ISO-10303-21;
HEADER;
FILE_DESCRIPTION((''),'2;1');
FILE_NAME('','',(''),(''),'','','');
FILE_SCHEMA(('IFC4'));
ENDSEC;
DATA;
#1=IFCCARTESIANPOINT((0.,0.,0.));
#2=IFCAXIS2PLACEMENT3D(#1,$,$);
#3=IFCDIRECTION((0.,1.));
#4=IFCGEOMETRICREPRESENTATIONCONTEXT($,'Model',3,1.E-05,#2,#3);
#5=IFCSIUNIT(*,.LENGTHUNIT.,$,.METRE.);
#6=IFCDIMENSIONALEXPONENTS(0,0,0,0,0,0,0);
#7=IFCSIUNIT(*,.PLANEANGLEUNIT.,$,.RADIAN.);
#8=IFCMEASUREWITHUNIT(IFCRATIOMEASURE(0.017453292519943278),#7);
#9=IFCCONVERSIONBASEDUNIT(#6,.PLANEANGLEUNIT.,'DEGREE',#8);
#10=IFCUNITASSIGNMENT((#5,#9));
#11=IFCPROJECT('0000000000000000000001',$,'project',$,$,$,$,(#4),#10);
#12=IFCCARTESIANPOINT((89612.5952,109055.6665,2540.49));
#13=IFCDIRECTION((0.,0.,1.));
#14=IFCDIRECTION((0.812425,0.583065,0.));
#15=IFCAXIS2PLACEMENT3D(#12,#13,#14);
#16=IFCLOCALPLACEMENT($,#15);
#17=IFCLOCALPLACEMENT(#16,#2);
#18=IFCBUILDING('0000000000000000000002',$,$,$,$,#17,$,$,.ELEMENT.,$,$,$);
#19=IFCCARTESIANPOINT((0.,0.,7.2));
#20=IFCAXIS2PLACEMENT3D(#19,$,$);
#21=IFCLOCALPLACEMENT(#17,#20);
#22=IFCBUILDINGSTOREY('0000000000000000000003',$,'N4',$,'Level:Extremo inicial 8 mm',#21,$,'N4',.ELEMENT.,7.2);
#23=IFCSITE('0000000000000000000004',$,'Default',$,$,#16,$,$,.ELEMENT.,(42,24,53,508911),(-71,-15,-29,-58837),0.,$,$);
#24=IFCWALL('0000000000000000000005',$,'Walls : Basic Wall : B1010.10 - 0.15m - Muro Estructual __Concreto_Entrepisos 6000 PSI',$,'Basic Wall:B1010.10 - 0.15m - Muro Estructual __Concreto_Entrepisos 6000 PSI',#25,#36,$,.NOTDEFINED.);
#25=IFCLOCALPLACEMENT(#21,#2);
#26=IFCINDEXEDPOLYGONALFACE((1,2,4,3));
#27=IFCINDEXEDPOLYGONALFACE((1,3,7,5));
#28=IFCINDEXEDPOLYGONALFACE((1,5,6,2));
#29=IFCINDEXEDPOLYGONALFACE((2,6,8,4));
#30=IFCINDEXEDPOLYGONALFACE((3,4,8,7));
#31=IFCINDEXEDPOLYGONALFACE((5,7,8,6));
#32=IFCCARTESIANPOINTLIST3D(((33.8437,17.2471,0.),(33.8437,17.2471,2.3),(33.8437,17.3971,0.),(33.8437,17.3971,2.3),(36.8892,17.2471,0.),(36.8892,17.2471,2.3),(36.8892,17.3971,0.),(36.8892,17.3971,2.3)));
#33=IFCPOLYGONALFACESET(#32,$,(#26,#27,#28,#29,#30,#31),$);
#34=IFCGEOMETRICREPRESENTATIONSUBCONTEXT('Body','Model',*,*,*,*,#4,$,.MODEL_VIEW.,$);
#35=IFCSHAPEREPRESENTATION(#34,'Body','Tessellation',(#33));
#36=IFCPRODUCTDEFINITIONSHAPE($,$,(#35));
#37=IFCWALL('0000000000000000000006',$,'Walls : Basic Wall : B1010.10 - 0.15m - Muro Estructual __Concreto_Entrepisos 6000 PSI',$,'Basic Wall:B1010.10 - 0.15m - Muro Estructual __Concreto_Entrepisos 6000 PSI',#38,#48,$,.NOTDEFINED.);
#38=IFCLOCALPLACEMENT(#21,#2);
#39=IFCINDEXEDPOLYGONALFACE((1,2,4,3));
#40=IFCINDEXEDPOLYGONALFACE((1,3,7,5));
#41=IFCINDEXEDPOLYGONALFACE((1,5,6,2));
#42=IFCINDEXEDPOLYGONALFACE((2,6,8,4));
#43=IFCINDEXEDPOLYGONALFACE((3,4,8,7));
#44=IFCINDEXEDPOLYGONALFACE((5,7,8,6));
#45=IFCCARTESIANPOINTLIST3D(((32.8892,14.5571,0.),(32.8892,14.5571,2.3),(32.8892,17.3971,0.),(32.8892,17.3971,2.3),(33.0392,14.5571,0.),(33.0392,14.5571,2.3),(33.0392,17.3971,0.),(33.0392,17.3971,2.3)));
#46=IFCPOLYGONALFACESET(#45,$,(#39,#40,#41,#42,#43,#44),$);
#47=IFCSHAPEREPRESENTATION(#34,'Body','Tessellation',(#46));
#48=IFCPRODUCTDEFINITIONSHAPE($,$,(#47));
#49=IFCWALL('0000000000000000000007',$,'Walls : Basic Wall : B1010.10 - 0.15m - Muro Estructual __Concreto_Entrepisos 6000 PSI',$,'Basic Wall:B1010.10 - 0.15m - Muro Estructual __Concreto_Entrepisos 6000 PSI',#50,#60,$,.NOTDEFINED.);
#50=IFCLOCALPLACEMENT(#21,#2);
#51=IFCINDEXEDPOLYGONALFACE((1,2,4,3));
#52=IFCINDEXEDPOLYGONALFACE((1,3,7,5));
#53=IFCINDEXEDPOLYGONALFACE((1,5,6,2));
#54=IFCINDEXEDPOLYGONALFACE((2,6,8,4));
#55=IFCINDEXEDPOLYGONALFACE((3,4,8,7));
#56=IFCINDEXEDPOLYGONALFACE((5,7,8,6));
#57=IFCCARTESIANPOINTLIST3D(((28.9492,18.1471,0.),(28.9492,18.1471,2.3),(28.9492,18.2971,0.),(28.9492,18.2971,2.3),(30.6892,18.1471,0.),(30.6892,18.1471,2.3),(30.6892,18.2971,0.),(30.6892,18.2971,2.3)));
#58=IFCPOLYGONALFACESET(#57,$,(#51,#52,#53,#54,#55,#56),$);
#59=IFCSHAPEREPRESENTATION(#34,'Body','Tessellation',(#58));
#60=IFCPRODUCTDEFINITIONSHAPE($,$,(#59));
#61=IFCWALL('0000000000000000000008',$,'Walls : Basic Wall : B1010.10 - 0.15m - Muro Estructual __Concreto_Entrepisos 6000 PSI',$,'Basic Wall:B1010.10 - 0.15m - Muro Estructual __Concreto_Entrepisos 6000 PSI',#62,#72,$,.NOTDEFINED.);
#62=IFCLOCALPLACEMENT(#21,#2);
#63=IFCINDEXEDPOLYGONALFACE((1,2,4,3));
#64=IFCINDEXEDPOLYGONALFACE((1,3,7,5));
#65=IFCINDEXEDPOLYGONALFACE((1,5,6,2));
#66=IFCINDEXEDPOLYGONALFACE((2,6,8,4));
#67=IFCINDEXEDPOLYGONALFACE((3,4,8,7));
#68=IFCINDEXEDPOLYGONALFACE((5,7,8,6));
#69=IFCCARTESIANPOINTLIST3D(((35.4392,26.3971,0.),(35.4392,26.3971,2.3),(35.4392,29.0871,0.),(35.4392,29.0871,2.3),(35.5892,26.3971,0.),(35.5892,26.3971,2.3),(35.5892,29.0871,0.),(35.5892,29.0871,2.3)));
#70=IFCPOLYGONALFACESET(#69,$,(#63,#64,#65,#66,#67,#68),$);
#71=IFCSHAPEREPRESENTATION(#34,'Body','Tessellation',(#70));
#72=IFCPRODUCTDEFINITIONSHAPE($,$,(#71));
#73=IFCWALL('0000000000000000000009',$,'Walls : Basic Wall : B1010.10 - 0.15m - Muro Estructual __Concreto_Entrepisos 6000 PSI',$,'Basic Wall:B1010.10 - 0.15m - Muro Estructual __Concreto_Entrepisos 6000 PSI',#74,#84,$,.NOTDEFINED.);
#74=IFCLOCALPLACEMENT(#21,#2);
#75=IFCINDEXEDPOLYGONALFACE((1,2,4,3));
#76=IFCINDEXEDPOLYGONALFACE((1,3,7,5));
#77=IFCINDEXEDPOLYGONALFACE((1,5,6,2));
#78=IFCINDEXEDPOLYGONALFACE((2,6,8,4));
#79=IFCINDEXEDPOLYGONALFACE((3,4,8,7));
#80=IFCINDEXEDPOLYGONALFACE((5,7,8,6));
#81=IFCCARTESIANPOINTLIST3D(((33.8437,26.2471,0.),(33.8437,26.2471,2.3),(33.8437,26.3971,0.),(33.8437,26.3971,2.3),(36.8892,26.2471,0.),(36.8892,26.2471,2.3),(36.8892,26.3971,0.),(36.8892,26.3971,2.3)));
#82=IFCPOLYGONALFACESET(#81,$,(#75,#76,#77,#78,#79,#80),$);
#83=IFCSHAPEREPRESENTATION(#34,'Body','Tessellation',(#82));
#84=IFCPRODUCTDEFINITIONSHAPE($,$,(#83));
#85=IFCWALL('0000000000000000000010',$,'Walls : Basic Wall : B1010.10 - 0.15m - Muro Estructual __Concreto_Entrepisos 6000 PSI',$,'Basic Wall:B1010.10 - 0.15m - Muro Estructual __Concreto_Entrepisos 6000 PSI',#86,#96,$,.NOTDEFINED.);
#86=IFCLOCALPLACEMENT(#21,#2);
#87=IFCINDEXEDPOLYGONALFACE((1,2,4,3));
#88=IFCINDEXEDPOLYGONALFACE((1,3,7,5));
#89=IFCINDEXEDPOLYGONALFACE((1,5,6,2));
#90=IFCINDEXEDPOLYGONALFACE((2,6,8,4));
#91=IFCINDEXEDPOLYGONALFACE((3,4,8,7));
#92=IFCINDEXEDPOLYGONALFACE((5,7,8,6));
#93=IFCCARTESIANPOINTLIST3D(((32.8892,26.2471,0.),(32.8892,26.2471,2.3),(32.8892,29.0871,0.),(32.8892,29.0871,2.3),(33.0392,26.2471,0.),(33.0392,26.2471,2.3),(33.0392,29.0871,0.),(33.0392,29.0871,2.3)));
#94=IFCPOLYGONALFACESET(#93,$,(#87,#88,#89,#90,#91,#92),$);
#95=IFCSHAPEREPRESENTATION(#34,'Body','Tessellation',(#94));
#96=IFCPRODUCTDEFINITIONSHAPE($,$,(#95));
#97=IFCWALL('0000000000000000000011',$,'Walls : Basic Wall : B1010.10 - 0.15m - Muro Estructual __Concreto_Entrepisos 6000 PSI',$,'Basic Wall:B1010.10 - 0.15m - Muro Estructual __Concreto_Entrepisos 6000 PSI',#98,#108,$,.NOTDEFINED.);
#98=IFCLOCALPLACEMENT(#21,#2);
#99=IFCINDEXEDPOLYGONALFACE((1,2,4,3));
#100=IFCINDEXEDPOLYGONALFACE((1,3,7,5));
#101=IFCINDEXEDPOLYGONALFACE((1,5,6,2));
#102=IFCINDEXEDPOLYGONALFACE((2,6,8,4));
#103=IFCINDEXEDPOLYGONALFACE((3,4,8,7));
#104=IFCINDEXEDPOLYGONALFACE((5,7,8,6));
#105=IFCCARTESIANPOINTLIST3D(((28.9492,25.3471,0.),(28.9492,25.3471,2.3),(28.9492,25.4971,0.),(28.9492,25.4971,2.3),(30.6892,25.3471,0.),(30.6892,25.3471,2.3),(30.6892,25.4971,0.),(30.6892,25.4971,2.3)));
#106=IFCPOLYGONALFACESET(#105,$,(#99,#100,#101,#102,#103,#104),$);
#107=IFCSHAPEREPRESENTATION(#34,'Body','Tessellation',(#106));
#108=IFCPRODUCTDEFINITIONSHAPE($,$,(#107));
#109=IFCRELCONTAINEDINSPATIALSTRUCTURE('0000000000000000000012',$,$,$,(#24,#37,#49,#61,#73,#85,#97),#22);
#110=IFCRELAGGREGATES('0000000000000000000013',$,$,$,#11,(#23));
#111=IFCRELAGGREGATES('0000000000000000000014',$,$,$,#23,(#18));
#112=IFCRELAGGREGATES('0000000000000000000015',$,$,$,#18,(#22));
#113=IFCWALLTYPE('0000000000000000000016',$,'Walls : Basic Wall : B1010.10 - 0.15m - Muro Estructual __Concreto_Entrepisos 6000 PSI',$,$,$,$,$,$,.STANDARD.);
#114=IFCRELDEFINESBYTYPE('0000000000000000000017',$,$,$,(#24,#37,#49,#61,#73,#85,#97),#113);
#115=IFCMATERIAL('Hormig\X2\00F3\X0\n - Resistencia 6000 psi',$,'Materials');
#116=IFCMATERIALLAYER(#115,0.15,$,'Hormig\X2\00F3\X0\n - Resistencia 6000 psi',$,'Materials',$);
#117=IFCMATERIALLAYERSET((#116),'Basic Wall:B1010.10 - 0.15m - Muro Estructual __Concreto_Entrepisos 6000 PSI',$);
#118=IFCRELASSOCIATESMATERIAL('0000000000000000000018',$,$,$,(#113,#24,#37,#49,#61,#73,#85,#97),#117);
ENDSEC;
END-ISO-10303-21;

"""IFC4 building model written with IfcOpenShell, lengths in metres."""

from ifc_helpers import new_model, entity, si_unit, converted_unit, direction, frame, frame_2d, origin, place, context, subcontext, project, spatial, rectangle, extrude, material, layer, layer_set, layer_usage, type_object, element, save


model = new_model("IFC4")

# Units and contexts
model_context = context("Model", 3, precision=1e-05, world=origin(), true_north=direction((0.0, 1.0)))
body_context = subcontext(model_context, "Body", "Model", "MODEL_VIEW")
ifc_project = project(units=[si_unit("LENGTHUNIT", "METRE"), converted_unit("PLANEANGLEUNIT", "DEGREE", entity("IfcRatioMeasure", 0.017453292519943278), si_unit("PLANEANGLEUNIT", "RADIAN"), dimensions=[0, 0, 0, 0, 0, 0, 0])], contexts=[model_context])

# Site, building, storey
site_placement = place(None, frame((89612.5952, 109055.6665, 2540.49), z_axis=(0.0, 0.0, 1.0), x_axis=(0.812425, 0.583065, 0.0)))
site = spatial("IfcSite", under=ifc_project, at=site_placement, Name="Default", CompositionType="ELEMENT", RefLatitude=(42, 24, 53, 508911), RefLongitude=(-71, -15, -29, -58837), RefElevation=0.0)
building_placement = place(site_placement, origin())
building = spatial("IfcBuilding", under=site, at=building_placement, CompositionType="ELEMENT")
storey_placement = place(building_placement, frame((0.0, 0.0, 7.2)))
storey = spatial("IfcBuildingStorey", under=building, at=storey_placement, Name="N4", ObjectType="Level:Extremo inicial 8 mm", LongName="N4", CompositionType="ELEMENT", Elevation=7.2)

# Walls
ifc_material = material(Name="Hormigón - Resistencia 6000 psi", Category="Materials")
ifc_layer_1 = layer(ifc_material, 0.15, Name="Hormigón - Resistencia 6000 psi", Category="Materials")
ifc_layer_set_1 = layer_set([ifc_layer_1], Name="Basic Wall:B1010.10 - 0.15m - Muro Estructual __Concreto_Entrepisos 6000 PSI")
wall_type_1 = type_object("IfcWallType", Name="Walls : Basic Wall : B1010.10 - 0.15m - Muro Estructual __Concreto_Entrepisos 6000 PSI", PredefinedType="STANDARD", material=ifc_layer_set_1)
ifc_layer_usage_1 = layer_usage(ifc_layer_set_1, "AXIS2", "NEGATIVE", 0.075)
wall_1_placement = place(storey_placement, frame((36.8892, 17.3221, 0.0), z_axis=(0.0, 0.0, 1.0), x_axis=(-1.0, 0.0, 0.0)))
element("IfcWall", 1, at=wall_1_placement, inside=storey, type_object=wall_type_1, material=ifc_layer_usage_1, Name="Walls : Basic Wall : B1010.10 - 0.15m - Muro Estructual __Concreto_Entrepisos 6000 PSI", ObjectType="Basic Wall:B1010.10 - 0.15m - Muro Estructual __Concreto_Entrepisos 6000 PSI", PredefinedType="NOTDEFINED", context=body_context, shape_type="SweptSolid", body=[
    extrude(rectangle(XDim=3.0455, YDim=0.15, at=frame_2d((1.5228, 0.0), x_axis=(-1.0, 0.0))), origin(), (0.0, 0.0, 1.0), 2.3),
])
ifc_layer_usage_2 = layer_usage(ifc_layer_set_1, "AXIS2", "NEGATIVE", 0.075)
wall_2_placement = place(storey_placement, frame((32.9642, 14.5571, 0.0), z_axis=(0.0, 0.0, 1.0), x_axis=(0.0, 1.0, 0.0)))
element("IfcWall", 2, at=wall_2_placement, inside=storey, type_object=wall_type_1, material=ifc_layer_usage_2, Name="Walls : Basic Wall : B1010.10 - 0.15m - Muro Estructual __Concreto_Entrepisos 6000 PSI", ObjectType="Basic Wall:B1010.10 - 0.15m - Muro Estructual __Concreto_Entrepisos 6000 PSI", PredefinedType="NOTDEFINED", context=body_context, shape_type="SweptSolid", body=[
    extrude(rectangle(XDim=2.84, YDim=0.15, at=frame_2d((1.42, 0.0), x_axis=(-1.0, 0.0))), origin(), (0.0, 0.0, 1.0), 2.3),
])
ifc_layer_usage_3 = layer_usage(ifc_layer_set_1, "AXIS2", "NEGATIVE", 0.075)
wall_3_placement = place(storey_placement, frame((30.6892, 18.2221, 0.0), z_axis=(0.0, 0.0, 1.0), x_axis=(-1.0, 0.0, 0.0)))
element("IfcWall", 3, at=wall_3_placement, inside=storey, type_object=wall_type_1, material=ifc_layer_usage_3, Name="Walls : Basic Wall : B1010.10 - 0.15m - Muro Estructual __Concreto_Entrepisos 6000 PSI", ObjectType="Basic Wall:B1010.10 - 0.15m - Muro Estructual __Concreto_Entrepisos 6000 PSI", PredefinedType="NOTDEFINED", context=body_context, shape_type="SweptSolid", body=[
    extrude(rectangle(XDim=1.74, YDim=0.15, at=frame_2d((0.87, 0.0), x_axis=(-1.0, 0.0))), origin(), (0.0, 0.0, 1.0), 2.3),
])
ifc_layer_usage_4 = layer_usage(ifc_layer_set_1, "AXIS2", "POSITIVE", -0.075)
wall_4_placement = place(storey_placement, frame((35.5142, 29.0871, 0.0), z_axis=(0.0, 0.0, 1.0), x_axis=(0.0, -1.0, 0.0)))
element("IfcWall", 4, at=wall_4_placement, inside=storey, type_object=wall_type_1, material=ifc_layer_usage_4, Name="Walls : Basic Wall : B1010.10 - 0.15m - Muro Estructual __Concreto_Entrepisos 6000 PSI", ObjectType="Basic Wall:B1010.10 - 0.15m - Muro Estructual __Concreto_Entrepisos 6000 PSI", PredefinedType="NOTDEFINED", context=body_context, shape_type="SweptSolid", body=[
    extrude(rectangle(XDim=2.69, YDim=0.15, at=frame_2d((1.345, 0.0), x_axis=(-1.0, 0.0))), origin(), (0.0, 0.0, 1.0), 2.3),
])
ifc_layer_usage_5 = layer_usage(ifc_layer_set_1, "AXIS2", "POSITIVE", -0.075)
wall_5_placement = place(storey_placement, frame((36.8892, 26.3221, 0.0), z_axis=(0.0, 0.0, 1.0), x_axis=(-1.0, 0.0, 0.0)))
element("IfcWall", 5, at=wall_5_placement, inside=storey, type_object=wall_type_1, material=ifc_layer_usage_5, Name="Walls : Basic Wall : B1010.10 - 0.15m - Muro Estructual __Concreto_Entrepisos 6000 PSI", ObjectType="Basic Wall:B1010.10 - 0.15m - Muro Estructual __Concreto_Entrepisos 6000 PSI", PredefinedType="NOTDEFINED", context=body_context, shape_type="SweptSolid", body=[
    extrude(rectangle(XDim=3.0455, YDim=0.15, at=frame_2d((1.5228, 0.0), x_axis=(-1.0, 0.0))), origin(), (0.0, 0.0, 1.0), 2.3),
])
ifc_layer_usage_6 = layer_usage(ifc_layer_set_1, "AXIS2", "POSITIVE", -0.075)
wall_6_placement = place(storey_placement, frame((32.9642, 29.0871, 0.0), z_axis=(0.0, 0.0, 1.0), x_axis=(0.0, -1.0, 0.0)))
element("IfcWall", 6, at=wall_6_placement, inside=storey, type_object=wall_type_1, material=ifc_layer_usage_6, Name="Walls : Basic Wall : B1010.10 - 0.15m - Muro Estructual __Concreto_Entrepisos 6000 PSI", ObjectType="Basic Wall:B1010.10 - 0.15m - Muro Estructual __Concreto_Entrepisos 6000 PSI", PredefinedType="NOTDEFINED", context=body_context, shape_type="SweptSolid", body=[
    extrude(rectangle(XDim=2.84, YDim=0.15, at=frame_2d((1.42, 0.0), x_axis=(-1.0, 0.0))), origin(), (0.0, 0.0, 1.0), 2.3),
])
ifc_layer_usage_7 = layer_usage(ifc_layer_set_1, "AXIS2", "POSITIVE", -0.075)
wall_7_placement = place(storey_placement, frame((30.6892, 25.4221, 0.0), z_axis=(0.0, 0.0, 1.0), x_axis=(-1.0, 0.0, 0.0)))
element("IfcWall", 7, at=wall_7_placement, inside=storey, type_object=wall_type_1, material=ifc_layer_usage_7, Name="Walls : Basic Wall : B1010.10 - 0.15m - Muro Estructual __Concreto_Entrepisos 6000 PSI", ObjectType="Basic Wall:B1010.10 - 0.15m - Muro Estructual __Concreto_Entrepisos 6000 PSI", PredefinedType="NOTDEFINED", context=body_context, shape_type="SweptSolid", body=[
    extrude(rectangle(XDim=1.74, YDim=0.15, at=frame_2d((0.87, 0.0), x_axis=(-1.0, 0.0))), origin(), (0.0, 0.0, 1.0), 2.3),
])

save(model, "model.ifc")
